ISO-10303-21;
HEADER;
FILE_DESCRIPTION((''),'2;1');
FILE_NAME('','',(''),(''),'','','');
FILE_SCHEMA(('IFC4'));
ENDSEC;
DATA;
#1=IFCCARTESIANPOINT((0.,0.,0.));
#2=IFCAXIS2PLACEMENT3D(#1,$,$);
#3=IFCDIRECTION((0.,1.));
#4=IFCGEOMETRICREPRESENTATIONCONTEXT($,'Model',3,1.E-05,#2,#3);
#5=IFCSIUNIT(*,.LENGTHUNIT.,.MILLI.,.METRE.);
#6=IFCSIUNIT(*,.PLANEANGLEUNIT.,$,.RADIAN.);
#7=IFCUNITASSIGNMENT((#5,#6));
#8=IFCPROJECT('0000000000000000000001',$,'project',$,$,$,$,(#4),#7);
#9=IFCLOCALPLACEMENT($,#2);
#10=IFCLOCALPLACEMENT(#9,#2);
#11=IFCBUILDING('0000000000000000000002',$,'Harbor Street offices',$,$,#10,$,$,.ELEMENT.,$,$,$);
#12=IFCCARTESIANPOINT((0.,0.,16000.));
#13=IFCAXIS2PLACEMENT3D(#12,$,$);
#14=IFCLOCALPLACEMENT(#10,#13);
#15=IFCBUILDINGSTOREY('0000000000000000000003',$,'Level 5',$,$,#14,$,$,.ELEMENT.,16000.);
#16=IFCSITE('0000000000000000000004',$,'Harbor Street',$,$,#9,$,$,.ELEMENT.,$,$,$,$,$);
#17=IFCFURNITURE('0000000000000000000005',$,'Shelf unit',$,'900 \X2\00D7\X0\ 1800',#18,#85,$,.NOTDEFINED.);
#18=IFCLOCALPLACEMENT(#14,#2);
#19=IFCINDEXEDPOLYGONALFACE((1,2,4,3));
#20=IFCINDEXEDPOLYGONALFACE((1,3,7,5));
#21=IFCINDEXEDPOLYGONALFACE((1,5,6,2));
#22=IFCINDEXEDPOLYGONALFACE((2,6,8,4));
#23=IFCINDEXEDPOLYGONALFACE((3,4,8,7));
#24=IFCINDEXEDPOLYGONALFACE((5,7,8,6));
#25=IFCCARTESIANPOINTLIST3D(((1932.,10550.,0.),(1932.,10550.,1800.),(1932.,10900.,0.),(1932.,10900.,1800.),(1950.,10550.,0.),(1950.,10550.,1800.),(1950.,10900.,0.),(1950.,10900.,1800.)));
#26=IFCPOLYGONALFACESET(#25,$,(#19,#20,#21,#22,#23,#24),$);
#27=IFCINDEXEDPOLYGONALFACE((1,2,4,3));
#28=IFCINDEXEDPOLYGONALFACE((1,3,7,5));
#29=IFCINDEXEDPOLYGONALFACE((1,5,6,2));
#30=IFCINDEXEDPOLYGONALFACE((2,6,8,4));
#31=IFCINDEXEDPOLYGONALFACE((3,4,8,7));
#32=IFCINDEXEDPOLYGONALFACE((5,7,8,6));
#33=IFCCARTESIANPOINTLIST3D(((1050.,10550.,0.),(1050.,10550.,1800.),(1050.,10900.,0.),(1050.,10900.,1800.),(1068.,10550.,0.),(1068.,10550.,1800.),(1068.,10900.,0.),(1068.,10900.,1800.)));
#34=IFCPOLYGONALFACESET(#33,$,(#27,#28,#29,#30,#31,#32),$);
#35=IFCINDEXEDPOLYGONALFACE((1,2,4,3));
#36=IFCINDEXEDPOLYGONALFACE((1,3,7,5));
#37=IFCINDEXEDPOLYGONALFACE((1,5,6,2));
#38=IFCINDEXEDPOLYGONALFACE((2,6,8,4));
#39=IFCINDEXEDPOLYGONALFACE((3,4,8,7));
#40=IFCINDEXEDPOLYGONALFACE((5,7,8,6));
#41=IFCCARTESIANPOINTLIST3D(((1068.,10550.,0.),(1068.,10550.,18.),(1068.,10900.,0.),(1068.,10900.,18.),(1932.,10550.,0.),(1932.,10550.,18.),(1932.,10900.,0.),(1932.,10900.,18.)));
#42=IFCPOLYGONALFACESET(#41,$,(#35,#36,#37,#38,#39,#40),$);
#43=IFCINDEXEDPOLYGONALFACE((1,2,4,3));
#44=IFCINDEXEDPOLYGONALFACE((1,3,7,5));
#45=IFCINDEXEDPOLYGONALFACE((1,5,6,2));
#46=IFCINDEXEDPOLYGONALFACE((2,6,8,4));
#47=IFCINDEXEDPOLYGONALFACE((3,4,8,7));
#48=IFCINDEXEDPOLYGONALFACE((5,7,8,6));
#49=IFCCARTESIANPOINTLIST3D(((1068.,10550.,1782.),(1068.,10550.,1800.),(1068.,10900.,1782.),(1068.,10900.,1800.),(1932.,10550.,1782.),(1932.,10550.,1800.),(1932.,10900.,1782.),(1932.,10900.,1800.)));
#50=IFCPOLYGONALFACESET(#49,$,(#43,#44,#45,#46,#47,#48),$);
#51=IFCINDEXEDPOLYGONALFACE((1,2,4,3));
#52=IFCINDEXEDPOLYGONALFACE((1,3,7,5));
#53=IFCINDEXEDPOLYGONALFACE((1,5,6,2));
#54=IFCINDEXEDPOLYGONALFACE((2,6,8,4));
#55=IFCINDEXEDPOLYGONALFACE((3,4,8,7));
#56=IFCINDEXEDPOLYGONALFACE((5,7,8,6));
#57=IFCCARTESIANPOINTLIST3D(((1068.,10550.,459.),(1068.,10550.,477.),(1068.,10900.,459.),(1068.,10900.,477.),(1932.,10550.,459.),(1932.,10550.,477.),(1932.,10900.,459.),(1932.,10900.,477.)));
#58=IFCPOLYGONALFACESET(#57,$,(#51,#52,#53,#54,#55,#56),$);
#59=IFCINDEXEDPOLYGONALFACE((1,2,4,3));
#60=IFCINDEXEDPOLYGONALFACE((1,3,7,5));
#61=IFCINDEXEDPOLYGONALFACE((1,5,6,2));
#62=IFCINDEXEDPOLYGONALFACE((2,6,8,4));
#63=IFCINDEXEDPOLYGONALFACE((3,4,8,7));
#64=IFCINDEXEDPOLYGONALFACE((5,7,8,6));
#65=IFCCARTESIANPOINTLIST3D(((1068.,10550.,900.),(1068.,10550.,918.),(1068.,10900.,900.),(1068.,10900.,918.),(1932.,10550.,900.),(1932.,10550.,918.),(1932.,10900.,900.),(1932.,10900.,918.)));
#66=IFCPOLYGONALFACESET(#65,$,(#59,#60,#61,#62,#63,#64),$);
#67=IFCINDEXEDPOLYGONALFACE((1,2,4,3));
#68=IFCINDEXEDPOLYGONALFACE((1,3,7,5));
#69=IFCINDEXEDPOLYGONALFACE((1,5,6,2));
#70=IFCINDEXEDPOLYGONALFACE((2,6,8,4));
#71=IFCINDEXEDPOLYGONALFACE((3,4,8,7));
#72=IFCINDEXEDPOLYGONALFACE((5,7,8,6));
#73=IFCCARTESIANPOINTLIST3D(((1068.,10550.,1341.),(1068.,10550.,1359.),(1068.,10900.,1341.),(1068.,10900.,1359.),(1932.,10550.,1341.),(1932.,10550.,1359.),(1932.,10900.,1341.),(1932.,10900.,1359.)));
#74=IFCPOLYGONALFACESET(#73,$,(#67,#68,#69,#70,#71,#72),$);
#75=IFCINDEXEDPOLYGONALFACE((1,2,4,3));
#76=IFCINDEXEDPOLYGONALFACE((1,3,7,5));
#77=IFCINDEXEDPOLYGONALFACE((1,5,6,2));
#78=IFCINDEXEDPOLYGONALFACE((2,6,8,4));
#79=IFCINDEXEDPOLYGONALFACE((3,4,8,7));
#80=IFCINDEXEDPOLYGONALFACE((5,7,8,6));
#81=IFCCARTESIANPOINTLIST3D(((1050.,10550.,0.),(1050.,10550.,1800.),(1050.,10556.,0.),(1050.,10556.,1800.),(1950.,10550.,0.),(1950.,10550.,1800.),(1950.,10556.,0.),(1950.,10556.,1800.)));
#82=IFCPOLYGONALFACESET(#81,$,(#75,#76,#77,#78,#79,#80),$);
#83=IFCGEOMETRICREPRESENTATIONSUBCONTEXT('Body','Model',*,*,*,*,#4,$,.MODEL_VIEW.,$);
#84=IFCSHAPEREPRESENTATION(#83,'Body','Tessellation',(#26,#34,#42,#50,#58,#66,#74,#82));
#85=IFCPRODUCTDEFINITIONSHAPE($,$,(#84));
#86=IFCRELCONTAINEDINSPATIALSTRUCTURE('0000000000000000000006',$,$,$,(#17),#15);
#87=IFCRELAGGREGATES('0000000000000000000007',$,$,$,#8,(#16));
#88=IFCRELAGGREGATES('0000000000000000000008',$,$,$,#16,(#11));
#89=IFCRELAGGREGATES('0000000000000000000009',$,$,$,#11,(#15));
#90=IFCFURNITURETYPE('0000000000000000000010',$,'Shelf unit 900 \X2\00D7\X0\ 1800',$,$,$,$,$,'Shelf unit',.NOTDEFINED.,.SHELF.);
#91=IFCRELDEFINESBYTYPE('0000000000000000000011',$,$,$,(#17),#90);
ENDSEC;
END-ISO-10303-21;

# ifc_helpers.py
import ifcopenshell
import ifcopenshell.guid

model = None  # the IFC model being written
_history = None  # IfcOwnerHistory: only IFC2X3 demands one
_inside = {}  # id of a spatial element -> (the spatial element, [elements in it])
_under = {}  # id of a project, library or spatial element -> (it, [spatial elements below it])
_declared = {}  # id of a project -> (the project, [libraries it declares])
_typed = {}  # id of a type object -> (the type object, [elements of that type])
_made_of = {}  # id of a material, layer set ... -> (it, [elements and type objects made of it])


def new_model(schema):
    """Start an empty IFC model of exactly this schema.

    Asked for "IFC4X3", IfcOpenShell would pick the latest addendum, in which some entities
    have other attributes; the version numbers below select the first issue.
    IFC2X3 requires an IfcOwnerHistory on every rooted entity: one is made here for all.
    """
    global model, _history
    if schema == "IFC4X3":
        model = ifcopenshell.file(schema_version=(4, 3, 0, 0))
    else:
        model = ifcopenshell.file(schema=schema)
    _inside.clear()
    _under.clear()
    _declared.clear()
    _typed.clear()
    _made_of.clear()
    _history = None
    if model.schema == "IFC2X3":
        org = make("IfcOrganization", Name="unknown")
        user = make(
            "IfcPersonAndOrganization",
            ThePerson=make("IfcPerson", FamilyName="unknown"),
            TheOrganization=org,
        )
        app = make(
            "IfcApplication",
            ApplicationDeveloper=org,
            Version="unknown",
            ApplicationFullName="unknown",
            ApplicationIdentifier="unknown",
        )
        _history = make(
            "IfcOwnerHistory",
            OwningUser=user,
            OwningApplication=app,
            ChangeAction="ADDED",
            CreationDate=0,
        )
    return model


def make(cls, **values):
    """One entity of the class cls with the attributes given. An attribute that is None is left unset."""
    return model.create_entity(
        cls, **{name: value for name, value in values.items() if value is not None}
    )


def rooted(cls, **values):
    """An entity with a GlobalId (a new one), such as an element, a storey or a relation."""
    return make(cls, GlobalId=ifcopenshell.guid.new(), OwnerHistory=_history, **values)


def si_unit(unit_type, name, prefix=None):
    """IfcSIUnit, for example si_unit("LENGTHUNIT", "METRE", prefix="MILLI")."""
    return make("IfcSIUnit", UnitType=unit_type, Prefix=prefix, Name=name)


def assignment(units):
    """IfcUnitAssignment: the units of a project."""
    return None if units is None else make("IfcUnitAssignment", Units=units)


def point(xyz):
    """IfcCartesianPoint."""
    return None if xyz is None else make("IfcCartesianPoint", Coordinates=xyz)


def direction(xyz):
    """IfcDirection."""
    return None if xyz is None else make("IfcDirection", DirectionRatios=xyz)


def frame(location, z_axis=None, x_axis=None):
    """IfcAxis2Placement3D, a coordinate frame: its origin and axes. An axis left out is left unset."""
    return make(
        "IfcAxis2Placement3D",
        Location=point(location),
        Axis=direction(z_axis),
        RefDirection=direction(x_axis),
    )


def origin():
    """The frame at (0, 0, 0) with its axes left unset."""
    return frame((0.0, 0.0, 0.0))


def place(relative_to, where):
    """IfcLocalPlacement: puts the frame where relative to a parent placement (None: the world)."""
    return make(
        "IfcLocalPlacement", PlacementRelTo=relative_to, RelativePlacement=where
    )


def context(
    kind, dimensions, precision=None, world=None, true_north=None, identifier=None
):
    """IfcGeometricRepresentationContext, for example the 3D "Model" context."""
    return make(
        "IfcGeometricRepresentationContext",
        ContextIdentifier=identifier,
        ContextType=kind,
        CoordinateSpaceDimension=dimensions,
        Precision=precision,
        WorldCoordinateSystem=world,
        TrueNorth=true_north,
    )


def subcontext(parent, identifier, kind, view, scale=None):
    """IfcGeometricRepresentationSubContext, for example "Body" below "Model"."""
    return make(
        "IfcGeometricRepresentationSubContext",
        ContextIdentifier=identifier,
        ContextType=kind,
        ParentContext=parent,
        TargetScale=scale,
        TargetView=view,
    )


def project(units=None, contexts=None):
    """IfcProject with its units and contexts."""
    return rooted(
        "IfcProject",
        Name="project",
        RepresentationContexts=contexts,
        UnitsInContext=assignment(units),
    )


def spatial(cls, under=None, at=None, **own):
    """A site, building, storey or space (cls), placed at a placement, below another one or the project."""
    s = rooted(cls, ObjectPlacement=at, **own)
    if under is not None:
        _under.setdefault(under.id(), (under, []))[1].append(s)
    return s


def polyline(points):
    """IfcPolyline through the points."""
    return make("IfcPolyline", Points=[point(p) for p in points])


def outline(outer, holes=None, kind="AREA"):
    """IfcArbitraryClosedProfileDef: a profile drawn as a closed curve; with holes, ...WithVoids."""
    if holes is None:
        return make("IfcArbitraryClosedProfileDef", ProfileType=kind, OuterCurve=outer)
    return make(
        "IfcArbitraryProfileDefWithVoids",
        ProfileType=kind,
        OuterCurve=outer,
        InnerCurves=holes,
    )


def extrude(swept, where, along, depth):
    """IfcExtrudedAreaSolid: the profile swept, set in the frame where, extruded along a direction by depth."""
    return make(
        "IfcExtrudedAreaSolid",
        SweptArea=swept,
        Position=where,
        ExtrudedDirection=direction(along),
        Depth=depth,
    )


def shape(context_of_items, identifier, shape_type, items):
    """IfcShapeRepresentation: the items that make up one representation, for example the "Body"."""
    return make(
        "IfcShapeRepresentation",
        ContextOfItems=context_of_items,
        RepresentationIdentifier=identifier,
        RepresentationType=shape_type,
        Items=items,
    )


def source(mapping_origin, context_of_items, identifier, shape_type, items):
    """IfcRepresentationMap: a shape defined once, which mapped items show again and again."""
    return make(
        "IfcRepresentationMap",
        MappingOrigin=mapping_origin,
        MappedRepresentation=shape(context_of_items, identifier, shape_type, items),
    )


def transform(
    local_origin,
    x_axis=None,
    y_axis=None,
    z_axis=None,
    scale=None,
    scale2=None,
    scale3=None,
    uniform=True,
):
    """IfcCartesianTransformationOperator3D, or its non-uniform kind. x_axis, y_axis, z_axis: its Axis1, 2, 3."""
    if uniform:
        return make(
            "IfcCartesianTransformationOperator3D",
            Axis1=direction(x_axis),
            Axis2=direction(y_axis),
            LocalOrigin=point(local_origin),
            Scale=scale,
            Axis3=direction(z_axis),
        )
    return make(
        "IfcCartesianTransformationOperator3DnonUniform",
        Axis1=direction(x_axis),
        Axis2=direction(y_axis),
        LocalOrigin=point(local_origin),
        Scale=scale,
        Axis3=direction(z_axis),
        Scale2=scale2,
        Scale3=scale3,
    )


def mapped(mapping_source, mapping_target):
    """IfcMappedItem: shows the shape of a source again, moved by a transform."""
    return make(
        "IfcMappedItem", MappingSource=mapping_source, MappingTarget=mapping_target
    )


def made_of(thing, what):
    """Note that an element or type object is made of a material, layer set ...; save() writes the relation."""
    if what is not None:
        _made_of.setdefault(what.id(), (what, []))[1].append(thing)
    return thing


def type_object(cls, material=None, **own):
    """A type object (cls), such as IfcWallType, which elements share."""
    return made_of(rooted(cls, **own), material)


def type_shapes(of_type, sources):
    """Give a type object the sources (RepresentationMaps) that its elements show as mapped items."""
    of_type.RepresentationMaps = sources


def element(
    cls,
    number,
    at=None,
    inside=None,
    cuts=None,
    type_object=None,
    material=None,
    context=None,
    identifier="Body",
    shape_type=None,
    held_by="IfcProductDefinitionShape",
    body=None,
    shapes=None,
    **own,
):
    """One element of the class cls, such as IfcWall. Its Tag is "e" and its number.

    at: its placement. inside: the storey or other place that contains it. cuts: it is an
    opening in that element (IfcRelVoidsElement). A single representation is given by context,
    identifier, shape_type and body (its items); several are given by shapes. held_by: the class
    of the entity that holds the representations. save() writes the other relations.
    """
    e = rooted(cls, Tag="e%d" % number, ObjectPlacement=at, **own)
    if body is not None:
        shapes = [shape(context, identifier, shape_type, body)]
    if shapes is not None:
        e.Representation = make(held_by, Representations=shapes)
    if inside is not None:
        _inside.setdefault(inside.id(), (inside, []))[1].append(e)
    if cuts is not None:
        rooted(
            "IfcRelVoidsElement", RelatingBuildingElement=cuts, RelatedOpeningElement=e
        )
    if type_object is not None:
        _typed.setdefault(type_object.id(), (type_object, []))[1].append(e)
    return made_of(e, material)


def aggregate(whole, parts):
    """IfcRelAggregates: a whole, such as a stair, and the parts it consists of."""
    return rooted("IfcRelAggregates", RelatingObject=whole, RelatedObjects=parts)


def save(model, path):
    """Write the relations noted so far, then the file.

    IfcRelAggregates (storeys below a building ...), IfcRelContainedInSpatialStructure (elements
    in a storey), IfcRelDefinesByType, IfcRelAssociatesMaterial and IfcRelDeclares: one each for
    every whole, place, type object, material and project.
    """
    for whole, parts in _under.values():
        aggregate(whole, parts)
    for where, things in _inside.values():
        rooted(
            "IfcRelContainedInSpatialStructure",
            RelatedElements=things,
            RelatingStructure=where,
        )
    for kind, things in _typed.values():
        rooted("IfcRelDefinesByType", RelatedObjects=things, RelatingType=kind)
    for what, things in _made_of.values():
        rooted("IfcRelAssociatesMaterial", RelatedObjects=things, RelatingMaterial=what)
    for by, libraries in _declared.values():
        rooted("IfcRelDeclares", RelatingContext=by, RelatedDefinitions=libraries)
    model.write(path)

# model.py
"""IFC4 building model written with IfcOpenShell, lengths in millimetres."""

from ifc_helpers import new_model, si_unit, direction, frame, origin, place, context, subcontext, project, spatial, polyline, outline, extrude, source, transform, mapped, type_object, type_shapes, element, save


model = new_model("IFC4")

# Units and contexts
model_context = context("Model", 3, precision=1e-05, world=origin(), true_north=direction((0.0, 1.0)))
body_context = subcontext(model_context, "Body", "Model", "MODEL_VIEW")
ifc_project = project(units=[si_unit("LENGTHUNIT", "METRE", prefix="MILLI"), si_unit("PLANEANGLEUNIT", "RADIAN")], contexts=[model_context])

# Site, building, storey
site_placement = place(None, origin())
site = spatial("IfcSite", under=ifc_project, at=site_placement, Name="Harbor Street", CompositionType="ELEMENT")
building_placement = place(site_placement, origin())
building = spatial("IfcBuilding", under=site, at=building_placement, Name="Harbor Street offices", CompositionType="ELEMENT")
storey_placement = place(building_placement, frame((0.0, 0.0, 16000.0)))
storey = spatial("IfcBuildingStorey", under=building, at=storey_placement, Name="Level 5", CompositionType="ELEMENT", Elevation=16000.0)

# Furniture
furniture_type_1 = type_object("IfcFurnitureType", Name="Shelf unit 900 × 1800", ElementType="Shelf unit", AssemblyPlace="NOTDEFINED", PredefinedType="SHELF")
shared_shape_1 = source(origin(), body_context, "Body", "SweptSolid", [
    extrude(outline(polyline([(-450.0, 0.0), (-432.0, 0.0), (-432.0, 350.0), (-450.0, 350.0), (-450.0, 0.0)])), origin(), (0.0, 0.0, 1.0), 1800.0),
    extrude(outline(polyline([(432.0, 0.0), (450.0, 0.0), (450.0, 350.0), (432.0, 350.0), (432.0, 0.0)])), origin(), (0.0, 0.0, 1.0), 1800.0),
    extrude(outline(polyline([(-432.0, 0.0), (432.0, 0.0), (432.0, 350.0), (-432.0, 350.0), (-432.0, 0.0)])), origin(), (0.0, 0.0, 1.0), 18.0),
    extrude(outline(polyline([(-432.0, 0.0), (432.0, 0.0), (432.0, 350.0), (-432.0, 350.0), (-432.0, 0.0)])), frame((0.0, 0.0, 1782.0)), (0.0, 0.0, 1.0), 18.0),
    extrude(outline(polyline([(-432.0, 0.0), (432.0, 0.0), (432.0, 350.0), (-432.0, 350.0), (-432.0, 0.0)])), frame((0.0, 0.0, 459.0)), (0.0, 0.0, 1.0), 18.0),
    extrude(outline(polyline([(-432.0, 0.0), (432.0, 0.0), (432.0, 350.0), (-432.0, 350.0), (-432.0, 0.0)])), frame((0.0, 0.0, 900.0)), (0.0, 0.0, 1.0), 18.0),
    extrude(outline(polyline([(-432.0, 0.0), (432.0, 0.0), (432.0, 350.0), (-432.0, 350.0), (-432.0, 0.0)])), frame((0.0, 0.0, 1341.0)), (0.0, 0.0, 1.0), 18.0),
    extrude(outline(polyline([(-450.0, 344.0), (450.0, 344.0), (450.0, 350.0), (-450.0, 350.0), (-450.0, 344.0)])), origin(), (0.0, 0.0, 1.0), 1800.0),
])
type_shapes(furniture_type_1, [shared_shape_1])
for number, where, z_axis, x_axis, name in (
    (1, (1500.0, 10900.0, 0.0), (0.0, 0.0, 1.0), (-1.0, 0.0, 0.0), "Shelf unit"),
):
    element("IfcFurniture", number, at=place(storey_placement, frame(where, z_axis=z_axis, x_axis=x_axis)), inside=storey, type_object=furniture_type_1, Name=name, ObjectType="900 × 1800", PredefinedType="NOTDEFINED", context=body_context, shape_type="MappedRepresentation", body=[
        mapped(shared_shape_1, transform((0.0, 0.0, 0.0))),
    ])

save(model, "model.ifc")
